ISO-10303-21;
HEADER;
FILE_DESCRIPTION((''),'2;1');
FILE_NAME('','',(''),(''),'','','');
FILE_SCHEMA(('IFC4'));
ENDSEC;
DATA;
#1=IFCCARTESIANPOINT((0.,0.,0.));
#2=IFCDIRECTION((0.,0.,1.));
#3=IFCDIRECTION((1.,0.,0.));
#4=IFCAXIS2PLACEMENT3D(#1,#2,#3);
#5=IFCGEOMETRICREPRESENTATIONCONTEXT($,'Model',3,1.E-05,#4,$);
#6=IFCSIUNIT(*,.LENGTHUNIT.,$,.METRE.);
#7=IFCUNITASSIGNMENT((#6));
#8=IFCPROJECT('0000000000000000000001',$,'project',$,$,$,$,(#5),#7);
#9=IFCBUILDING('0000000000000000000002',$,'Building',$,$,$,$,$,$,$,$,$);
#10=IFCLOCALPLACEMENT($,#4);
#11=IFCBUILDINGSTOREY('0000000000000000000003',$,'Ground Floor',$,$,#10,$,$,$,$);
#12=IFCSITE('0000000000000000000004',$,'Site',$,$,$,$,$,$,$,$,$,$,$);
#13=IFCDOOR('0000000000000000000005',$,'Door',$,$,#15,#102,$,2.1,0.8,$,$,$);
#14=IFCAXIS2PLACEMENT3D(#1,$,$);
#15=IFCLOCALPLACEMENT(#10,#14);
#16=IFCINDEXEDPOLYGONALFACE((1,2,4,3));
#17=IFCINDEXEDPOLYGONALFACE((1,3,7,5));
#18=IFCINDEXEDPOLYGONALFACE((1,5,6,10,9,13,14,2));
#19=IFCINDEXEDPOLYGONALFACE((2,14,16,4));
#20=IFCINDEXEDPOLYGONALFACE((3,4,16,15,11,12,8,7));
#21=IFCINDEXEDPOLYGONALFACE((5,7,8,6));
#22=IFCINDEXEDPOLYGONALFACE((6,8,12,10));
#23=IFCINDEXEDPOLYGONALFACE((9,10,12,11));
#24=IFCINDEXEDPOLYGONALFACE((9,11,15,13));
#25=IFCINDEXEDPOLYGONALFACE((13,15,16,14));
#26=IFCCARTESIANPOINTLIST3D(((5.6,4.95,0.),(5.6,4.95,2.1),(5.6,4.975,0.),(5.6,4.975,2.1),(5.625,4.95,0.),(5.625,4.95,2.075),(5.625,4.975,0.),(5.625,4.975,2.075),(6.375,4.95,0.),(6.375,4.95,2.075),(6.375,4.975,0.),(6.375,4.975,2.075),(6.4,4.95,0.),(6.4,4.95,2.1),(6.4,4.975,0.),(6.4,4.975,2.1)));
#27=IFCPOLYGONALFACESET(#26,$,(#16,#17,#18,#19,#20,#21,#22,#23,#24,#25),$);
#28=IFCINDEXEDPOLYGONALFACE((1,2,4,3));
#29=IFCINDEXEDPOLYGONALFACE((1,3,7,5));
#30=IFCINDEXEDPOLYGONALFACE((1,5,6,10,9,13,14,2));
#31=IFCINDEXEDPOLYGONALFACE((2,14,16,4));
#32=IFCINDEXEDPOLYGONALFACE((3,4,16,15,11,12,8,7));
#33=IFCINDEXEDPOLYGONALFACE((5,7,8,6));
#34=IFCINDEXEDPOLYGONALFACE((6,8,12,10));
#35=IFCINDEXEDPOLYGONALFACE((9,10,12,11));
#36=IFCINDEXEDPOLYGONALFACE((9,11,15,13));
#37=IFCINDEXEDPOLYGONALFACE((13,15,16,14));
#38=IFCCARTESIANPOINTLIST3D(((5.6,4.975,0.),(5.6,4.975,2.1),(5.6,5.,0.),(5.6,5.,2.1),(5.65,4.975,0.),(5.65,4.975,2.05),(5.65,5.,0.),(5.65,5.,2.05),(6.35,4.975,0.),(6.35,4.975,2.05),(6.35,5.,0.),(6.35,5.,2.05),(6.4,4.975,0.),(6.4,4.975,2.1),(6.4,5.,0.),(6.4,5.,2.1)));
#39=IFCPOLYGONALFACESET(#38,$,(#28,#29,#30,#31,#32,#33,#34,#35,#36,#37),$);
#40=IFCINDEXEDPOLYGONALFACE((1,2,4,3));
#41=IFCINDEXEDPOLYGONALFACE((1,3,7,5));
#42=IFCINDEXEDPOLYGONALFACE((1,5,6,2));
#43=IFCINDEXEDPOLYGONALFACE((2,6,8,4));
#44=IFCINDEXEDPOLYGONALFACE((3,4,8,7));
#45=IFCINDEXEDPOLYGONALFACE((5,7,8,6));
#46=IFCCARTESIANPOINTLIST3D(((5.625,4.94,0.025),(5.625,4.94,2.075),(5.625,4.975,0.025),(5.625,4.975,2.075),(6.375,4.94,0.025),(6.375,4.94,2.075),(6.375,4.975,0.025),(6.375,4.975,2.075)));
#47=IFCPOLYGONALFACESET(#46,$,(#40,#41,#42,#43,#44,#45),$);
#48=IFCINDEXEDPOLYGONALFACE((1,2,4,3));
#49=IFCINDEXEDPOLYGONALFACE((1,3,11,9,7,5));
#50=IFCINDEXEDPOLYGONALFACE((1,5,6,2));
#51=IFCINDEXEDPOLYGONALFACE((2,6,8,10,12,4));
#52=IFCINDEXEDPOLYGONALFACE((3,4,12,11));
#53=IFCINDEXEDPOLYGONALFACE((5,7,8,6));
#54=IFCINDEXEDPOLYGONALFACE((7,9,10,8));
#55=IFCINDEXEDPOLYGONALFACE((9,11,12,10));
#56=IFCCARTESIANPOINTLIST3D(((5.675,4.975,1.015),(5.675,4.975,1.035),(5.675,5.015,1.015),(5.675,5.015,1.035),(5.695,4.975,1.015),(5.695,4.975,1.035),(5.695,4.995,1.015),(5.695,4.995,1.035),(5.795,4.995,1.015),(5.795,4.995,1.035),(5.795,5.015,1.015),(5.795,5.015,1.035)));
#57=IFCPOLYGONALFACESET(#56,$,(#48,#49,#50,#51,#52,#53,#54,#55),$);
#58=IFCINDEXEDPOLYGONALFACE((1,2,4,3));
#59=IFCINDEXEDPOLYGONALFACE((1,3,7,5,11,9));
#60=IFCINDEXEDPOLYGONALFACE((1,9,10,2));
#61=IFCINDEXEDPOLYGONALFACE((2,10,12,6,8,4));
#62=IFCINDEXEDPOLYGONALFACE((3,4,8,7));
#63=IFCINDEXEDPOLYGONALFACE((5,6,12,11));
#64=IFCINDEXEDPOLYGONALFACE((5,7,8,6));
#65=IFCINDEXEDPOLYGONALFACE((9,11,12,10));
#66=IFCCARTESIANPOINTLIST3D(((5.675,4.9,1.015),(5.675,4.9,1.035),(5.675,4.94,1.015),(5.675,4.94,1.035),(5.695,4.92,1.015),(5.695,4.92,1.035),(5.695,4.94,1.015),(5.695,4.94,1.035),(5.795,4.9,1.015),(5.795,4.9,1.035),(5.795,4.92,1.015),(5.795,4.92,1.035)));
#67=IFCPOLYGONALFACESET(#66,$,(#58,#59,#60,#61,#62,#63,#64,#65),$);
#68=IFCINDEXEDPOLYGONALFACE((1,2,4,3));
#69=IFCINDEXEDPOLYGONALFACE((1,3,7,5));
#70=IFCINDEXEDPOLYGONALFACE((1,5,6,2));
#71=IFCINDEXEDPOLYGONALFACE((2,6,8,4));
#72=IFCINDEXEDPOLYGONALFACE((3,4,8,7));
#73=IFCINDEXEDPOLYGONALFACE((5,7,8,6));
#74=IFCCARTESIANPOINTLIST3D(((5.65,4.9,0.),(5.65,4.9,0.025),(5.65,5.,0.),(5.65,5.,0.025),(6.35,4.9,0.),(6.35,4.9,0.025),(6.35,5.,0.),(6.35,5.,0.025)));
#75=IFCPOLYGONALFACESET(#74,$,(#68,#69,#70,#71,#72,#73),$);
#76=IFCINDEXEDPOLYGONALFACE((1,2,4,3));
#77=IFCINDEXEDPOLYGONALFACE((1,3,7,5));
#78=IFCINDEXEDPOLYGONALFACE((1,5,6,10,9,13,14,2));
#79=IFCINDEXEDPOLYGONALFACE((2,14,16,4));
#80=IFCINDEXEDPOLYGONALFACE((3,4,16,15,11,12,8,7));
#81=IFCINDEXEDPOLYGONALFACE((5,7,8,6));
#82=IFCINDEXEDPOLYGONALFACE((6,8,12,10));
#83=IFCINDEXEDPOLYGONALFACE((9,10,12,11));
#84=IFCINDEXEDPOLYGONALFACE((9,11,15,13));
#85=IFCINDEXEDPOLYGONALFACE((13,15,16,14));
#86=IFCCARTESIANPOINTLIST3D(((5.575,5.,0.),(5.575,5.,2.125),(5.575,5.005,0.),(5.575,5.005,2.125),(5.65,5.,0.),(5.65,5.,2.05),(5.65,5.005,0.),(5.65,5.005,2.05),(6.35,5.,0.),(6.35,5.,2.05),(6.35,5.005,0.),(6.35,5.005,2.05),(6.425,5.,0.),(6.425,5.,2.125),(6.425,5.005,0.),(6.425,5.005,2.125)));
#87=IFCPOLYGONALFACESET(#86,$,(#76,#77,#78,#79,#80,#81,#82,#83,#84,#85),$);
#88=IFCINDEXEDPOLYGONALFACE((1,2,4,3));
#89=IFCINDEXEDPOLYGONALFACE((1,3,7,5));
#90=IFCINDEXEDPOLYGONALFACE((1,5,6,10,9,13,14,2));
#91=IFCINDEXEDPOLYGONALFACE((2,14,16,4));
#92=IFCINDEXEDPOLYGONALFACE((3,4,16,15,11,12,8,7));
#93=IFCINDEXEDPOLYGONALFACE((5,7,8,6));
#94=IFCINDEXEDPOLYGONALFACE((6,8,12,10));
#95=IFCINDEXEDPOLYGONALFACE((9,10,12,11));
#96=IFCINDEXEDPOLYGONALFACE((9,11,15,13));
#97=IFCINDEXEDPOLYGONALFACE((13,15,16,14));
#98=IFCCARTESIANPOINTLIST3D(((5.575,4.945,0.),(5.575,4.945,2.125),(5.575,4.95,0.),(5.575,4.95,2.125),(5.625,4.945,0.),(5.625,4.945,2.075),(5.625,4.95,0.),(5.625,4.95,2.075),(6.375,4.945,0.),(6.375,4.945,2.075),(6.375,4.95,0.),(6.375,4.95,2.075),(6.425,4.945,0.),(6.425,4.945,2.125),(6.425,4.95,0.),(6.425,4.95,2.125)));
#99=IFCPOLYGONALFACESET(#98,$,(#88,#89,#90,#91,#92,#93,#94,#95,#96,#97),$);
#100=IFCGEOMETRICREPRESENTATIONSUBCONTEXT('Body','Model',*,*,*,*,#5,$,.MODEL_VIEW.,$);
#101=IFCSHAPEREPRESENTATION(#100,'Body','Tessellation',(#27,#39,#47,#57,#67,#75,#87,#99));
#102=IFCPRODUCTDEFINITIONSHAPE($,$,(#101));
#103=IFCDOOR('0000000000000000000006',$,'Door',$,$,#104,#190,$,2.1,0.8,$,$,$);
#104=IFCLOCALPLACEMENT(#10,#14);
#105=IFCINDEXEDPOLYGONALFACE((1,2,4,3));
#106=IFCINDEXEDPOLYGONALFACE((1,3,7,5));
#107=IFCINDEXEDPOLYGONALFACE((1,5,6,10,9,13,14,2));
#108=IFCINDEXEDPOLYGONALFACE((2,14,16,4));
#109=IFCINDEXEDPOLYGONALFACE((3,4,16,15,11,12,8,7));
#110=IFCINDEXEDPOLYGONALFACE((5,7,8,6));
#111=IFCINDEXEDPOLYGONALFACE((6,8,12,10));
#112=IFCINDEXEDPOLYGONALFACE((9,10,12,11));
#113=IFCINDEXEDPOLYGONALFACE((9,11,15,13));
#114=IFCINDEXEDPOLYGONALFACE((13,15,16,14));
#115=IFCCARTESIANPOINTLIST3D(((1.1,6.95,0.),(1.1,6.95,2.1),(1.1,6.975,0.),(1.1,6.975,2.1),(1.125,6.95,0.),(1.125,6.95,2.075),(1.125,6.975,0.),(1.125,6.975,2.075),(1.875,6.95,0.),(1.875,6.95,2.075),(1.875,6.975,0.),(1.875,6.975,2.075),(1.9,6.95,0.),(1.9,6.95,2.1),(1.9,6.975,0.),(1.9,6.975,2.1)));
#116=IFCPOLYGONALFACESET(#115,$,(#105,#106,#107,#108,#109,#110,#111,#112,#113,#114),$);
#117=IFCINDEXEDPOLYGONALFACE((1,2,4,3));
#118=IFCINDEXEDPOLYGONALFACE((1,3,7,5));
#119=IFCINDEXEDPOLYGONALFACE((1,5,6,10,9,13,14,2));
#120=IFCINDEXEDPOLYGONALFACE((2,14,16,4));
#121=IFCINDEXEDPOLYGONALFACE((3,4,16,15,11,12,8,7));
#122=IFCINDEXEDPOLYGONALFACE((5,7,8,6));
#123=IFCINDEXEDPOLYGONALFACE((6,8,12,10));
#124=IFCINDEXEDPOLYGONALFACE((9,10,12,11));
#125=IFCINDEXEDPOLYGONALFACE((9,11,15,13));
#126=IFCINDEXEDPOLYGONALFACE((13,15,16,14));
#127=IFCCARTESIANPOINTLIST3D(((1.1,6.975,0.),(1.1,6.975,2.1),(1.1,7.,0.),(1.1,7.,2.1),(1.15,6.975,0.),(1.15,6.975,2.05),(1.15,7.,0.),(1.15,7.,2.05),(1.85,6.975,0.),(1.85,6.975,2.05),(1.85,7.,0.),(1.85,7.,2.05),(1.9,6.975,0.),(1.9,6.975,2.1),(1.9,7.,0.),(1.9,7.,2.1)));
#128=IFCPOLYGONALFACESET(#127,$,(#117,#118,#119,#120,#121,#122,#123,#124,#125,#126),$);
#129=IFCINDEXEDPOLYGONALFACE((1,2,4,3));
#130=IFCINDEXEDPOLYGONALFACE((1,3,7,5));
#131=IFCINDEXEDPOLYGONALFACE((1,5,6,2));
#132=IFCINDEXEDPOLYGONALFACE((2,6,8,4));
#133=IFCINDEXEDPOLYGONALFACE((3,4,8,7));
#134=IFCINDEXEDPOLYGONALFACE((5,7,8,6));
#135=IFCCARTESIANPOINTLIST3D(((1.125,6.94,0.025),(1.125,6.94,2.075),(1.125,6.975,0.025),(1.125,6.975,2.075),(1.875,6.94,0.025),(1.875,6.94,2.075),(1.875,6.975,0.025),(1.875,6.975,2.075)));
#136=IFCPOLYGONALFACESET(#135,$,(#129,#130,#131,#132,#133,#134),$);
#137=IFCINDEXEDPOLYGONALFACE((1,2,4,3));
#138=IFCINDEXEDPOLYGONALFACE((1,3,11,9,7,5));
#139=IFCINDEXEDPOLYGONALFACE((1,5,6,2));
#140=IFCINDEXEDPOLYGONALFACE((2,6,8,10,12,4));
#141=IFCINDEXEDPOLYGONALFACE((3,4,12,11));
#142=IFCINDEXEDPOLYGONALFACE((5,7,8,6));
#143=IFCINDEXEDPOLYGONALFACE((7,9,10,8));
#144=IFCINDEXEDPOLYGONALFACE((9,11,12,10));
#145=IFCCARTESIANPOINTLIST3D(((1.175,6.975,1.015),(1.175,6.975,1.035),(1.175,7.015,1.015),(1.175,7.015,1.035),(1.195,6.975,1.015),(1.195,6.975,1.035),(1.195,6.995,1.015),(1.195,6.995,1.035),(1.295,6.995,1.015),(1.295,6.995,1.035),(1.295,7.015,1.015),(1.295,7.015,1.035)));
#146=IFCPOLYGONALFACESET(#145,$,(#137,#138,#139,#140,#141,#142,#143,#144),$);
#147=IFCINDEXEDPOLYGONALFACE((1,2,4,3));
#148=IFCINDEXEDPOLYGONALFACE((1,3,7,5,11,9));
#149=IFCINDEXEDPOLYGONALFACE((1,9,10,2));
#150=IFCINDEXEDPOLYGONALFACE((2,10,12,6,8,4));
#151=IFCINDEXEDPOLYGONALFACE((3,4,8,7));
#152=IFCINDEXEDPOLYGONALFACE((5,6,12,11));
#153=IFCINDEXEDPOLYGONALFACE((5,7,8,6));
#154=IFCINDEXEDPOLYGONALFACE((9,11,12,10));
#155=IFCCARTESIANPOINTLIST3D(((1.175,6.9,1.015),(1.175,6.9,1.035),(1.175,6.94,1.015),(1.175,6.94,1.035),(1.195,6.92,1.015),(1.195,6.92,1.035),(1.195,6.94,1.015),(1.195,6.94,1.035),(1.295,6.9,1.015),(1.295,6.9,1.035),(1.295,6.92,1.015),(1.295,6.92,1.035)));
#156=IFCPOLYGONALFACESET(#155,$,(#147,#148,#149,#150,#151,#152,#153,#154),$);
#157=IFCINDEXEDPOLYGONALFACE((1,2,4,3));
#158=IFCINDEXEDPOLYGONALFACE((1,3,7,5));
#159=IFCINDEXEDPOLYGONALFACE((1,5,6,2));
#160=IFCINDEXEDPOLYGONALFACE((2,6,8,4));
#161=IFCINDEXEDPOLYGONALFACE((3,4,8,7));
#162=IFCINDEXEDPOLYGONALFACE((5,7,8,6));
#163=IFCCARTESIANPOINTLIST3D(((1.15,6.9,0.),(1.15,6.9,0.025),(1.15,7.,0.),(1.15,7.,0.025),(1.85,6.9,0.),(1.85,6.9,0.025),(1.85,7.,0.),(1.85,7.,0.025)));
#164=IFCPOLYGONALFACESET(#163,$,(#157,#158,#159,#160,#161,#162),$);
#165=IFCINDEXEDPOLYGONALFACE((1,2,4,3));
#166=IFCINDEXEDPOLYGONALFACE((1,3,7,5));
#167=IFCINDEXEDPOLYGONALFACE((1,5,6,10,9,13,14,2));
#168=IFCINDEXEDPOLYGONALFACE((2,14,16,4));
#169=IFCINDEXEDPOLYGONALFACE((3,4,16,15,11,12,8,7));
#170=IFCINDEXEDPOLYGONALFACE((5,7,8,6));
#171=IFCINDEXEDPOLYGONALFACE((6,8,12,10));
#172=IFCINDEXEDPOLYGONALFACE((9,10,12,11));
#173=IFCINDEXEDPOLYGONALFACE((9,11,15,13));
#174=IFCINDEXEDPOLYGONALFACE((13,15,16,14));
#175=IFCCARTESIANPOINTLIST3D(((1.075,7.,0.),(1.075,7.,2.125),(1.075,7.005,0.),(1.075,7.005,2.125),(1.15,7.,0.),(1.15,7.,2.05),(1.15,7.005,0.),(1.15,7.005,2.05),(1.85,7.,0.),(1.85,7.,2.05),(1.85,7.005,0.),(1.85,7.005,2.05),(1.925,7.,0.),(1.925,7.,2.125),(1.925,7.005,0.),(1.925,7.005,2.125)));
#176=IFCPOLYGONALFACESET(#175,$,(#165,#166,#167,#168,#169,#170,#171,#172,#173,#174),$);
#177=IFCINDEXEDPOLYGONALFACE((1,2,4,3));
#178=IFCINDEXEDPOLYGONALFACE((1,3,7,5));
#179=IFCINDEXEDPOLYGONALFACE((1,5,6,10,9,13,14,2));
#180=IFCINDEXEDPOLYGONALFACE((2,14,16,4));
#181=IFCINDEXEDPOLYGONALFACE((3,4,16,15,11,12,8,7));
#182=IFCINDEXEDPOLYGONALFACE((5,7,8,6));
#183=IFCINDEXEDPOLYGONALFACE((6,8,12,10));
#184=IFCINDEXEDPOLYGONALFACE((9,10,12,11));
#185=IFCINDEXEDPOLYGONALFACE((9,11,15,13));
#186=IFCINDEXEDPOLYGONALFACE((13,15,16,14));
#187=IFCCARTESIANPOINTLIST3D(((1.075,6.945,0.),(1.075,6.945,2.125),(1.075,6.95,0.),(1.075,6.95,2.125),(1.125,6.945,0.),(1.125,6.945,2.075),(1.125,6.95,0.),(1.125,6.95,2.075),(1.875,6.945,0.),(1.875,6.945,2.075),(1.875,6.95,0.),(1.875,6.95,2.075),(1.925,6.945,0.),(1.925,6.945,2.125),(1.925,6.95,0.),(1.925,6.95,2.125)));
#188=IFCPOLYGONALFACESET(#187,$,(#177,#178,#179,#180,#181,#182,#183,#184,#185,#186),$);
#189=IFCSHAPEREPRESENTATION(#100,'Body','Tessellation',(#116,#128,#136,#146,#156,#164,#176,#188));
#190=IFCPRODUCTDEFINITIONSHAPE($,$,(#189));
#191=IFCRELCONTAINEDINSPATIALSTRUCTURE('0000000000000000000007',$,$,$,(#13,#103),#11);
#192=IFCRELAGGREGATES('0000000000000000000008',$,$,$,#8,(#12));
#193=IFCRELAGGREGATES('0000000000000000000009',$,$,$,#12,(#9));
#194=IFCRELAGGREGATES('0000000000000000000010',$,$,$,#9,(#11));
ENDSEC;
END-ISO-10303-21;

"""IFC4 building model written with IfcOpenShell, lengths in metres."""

from ifc_helpers import new_model, si_unit, frame, origin_with_axes, place, context, subcontext, project, spatial, line, indexed_curve, outline, extrude, element, save


model = new_model("IFC4")

# Units and contexts
model_context = context("Model", 3, precision=1e-05, world=origin_with_axes())
body_context = subcontext(model_context, "Body", "Model", "MODEL_VIEW")
ifc_project = project(units=[si_unit("LENGTHUNIT", "METRE")], contexts=[model_context])

# Site, building, storey
site = spatial("IfcSite", under=ifc_project, Name="Site")
building = spatial("IfcBuilding", under=site, Name="Building")
storey_placement = place(None, origin_with_axes())
storey = spatial("IfcBuildingStorey", under=building, at=storey_placement, Name="Ground Floor")

# Doors
door_1_placement = place(storey_placement, frame((6.4, 5.0, 0.0), z_axis=(0.0, 0.0, 1.0), x_axis=(-1.0, 0.0, 0.0)))
element("IfcDoor", 1, at=door_1_placement, inside=storey, Name="Door", OverallHeight=2.1, OverallWidth=0.8, context=body_context, shape_type="SweptSolid", body=[
    extrude(outline(indexed_curve([(0.0, 0.0), (0.0, 2.1), (0.8, 2.1), (0.8, 0.0), (0.775, 0.0), (0.775, 2.075), (0.025, 2.075), (0.025, 0.0)], segments=[line(1, 2, 3, 4, 5, 6, 7, 8, 1)])), frame((0.0, 0.025, 0.0), z_axis=(0.0, -1.0, 0.0), x_axis=(1.0, 0.0, 0.0)), (0.0, 0.0, -1.0), 0.025),
    extrude(outline(indexed_curve([(0.0, 0.0), (0.0, 2.1), (0.8, 2.1), (0.8, 0.0), (0.75, 0.0), (0.75, 2.05), (0.05, 2.05), (0.05, 0.0)], segments=[line(1, 2, 3, 4, 5, 6, 7, 8, 1)])), frame((0.0, 0.0, 0.0), z_axis=(0.0, -1.0, 0.0), x_axis=(1.0, 0.0, 0.0)), (0.0, 0.0, -1.0), 0.025),
    extrude(outline(indexed_curve([(0.0, 0.0), (0.75, 0.0), (0.75, 0.035), (0.0, 0.035)], segments=[line(1, 2, 3, 4, 1)])), frame((0.025, 0.025, 0.025), z_axis=(0.0, 0.0, 1.0), x_axis=(1.0, 0.0, 0.0)), (0.0, 0.0, 1.0), 2.05),
    extrude(outline(indexed_curve([(0.0, 0.0), (0.0, -0.04), (-0.12, -0.04), (-0.12, -0.02), (-0.02, -0.02), (-0.02, 0.0)], segments=[line(1, 2, 3, 4, 5, 6, 1)])), frame((0.725, 0.025, 1.015), z_axis=(0.0, 0.0, 1.0), x_axis=(1.0, 0.0, 0.0)), (0.0, 0.0, 1.0), 0.02),
    extrude(outline(indexed_curve([(0.0, 0.0), (0.0, 0.04), (-0.12, 0.04), (-0.12, 0.02), (-0.02, 0.02), (-0.02, 0.0)], segments=[line(1, 2, 3, 4, 5, 6, 1)])), frame((0.725, 0.06, 1.015), z_axis=(0.0, 0.0, 1.0), x_axis=(1.0, 0.0, 0.0)), (0.0, 0.0, 1.0), 0.02),
    extrude(outline(indexed_curve([(0.0, 0.0), (0.7, 0.0), (0.7, 0.1), (0.0, 0.1)], segments=[line(1, 2, 3, 4, 1)])), frame((0.05, 0.0, 0.0), z_axis=(0.0, 0.0, 1.0), x_axis=(1.0, 0.0, 0.0)), (0.0, 0.0, 1.0), 0.025),
    extrude(outline(indexed_curve([(0.0, 0.0), (0.0, 2.125), (0.85, 2.125), (0.85, 0.0), (0.775, 0.0), (0.775, 2.05), (0.075, 2.05), (0.075, 0.0)], segments=[line(1, 2, 3, 4, 5, 6, 7, 8, 1)])), frame((-0.025, -0.005, 0.0), z_axis=(0.0, -1.0, 0.0), x_axis=(1.0, 0.0, 0.0)), (0.0, 0.0, -1.0), 0.005),
    extrude(outline(indexed_curve([(0.0, 0.0), (0.0, 2.125), (0.85, 2.125), (0.85, 0.0), (0.8, 0.0), (0.8, 2.075), (0.05, 2.075), (0.05, 0.0)], segments=[line(1, 2, 3, 4, 5, 6, 7, 8, 1)])), frame((-0.025, 0.05, 0.0), z_axis=(0.0, -1.0, 0.0), x_axis=(1.0, 0.0, 0.0)), (0.0, 0.0, -1.0), 0.005),
])
door_2_placement = place(storey_placement, frame((1.9, 7.0, 0.0), z_axis=(0.0, 0.0, 1.0), x_axis=(-1.0, 0.0, 0.0)))
element("IfcDoor", 2, at=door_2_placement, inside=storey, Name="Door", OverallHeight=2.1, OverallWidth=0.8, context=body_context, shape_type="SweptSolid", body=[
    extrude(outline(indexed_curve([(0.0, 0.0), (0.0, 2.1), (0.8, 2.1), (0.8, 0.0), (0.775, 0.0), (0.775, 2.075), (0.025, 2.075), (0.025, 0.0)], segments=[line(1, 2, 3, 4, 5, 6, 7, 8, 1)])), frame((0.0, 0.025, 0.0), z_axis=(0.0, -1.0, 0.0), x_axis=(1.0, 0.0, 0.0)), (0.0, 0.0, -1.0), 0.025),
    extrude(outline(indexed_curve([(0.0, 0.0), (0.0, 2.1), (0.8, 2.1), (0.8, 0.0), (0.75, 0.0), (0.75, 2.05), (0.05, 2.05), (0.05, 0.0)], segments=[line(1, 2, 3, 4, 5, 6, 7, 8, 1)])), frame((0.0, 0.0, 0.0), z_axis=(0.0, -1.0, 0.0), x_axis=(1.0, 0.0, 0.0)), (0.0, 0.0, -1.0), 0.025),
    extrude(outline(indexed_curve([(0.0, 0.0), (0.75, 0.0), (0.75, 0.035), (0.0, 0.035)], segments=[line(1, 2, 3, 4, 1)])), frame((0.025, 0.025, 0.025), z_axis=(0.0, 0.0, 1.0), x_axis=(1.0, 0.0, 0.0)), (0.0, 0.0, 1.0), 2.05),
    extrude(outline(indexed_curve([(0.0, 0.0), (0.0, -0.04), (-0.12, -0.04), (-0.12, -0.02), (-0.02, -0.02), (-0.02, 0.0)], segments=[line(1, 2, 3, 4, 5, 6, 1)])), frame((0.725, 0.025, 1.015), z_axis=(0.0, 0.0, 1.0), x_axis=(1.0, 0.0, 0.0)), (0.0, 0.0, 1.0), 0.02),
    extrude(outline(indexed_curve([(0.0, 0.0), (0.0, 0.04), (-0.12, 0.04), (-0.12, 0.02), (-0.02, 0.02), (-0.02, 0.0)], segments=[line(1, 2, 3, 4, 5, 6, 1)])), frame((0.725, 0.06, 1.015), z_axis=(0.0, 0.0, 1.0), x_axis=(1.0, 0.0, 0.0)), (0.0, 0.0, 1.0), 0.02),
    extrude(outline(indexed_curve([(0.0, 0.0), (0.7, 0.0), (0.7, 0.1), (0.0, 0.1)], segments=[line(1, 2, 3, 4, 1)])), frame((0.05, 0.0, 0.0), z_axis=(0.0, 0.0, 1.0), x_axis=(1.0, 0.0, 0.0)), (0.0, 0.0, 1.0), 0.025),
    extrude(outline(indexed_curve([(0.0, 0.0), (0.0, 2.125), (0.85, 2.125), (0.85, 0.0), (0.775, 0.0), (0.775, 2.05), (0.075, 2.05), (0.075, 0.0)], segments=[line(1, 2, 3, 4, 5, 6, 7, 8, 1)])), frame((-0.025, -0.005, 0.0), z_axis=(0.0, -1.0, 0.0), x_axis=(1.0, 0.0, 0.0)), (0.0, 0.0, -1.0), 0.005),
    extrude(outline(indexed_curve([(0.0, 0.0), (0.0, 2.125), (0.85, 2.125), (0.85, 0.0), (0.8, 0.0), (0.8, 2.075), (0.05, 2.075), (0.05, 0.0)], segments=[line(1, 2, 3, 4, 5, 6, 7, 8, 1)])), frame((-0.025, 0.05, 0.0), z_axis=(0.0, -1.0, 0.0), x_axis=(1.0, 0.0, 0.0)), (0.0, 0.0, -1.0), 0.005),
])

save(model, "model.ifc")
